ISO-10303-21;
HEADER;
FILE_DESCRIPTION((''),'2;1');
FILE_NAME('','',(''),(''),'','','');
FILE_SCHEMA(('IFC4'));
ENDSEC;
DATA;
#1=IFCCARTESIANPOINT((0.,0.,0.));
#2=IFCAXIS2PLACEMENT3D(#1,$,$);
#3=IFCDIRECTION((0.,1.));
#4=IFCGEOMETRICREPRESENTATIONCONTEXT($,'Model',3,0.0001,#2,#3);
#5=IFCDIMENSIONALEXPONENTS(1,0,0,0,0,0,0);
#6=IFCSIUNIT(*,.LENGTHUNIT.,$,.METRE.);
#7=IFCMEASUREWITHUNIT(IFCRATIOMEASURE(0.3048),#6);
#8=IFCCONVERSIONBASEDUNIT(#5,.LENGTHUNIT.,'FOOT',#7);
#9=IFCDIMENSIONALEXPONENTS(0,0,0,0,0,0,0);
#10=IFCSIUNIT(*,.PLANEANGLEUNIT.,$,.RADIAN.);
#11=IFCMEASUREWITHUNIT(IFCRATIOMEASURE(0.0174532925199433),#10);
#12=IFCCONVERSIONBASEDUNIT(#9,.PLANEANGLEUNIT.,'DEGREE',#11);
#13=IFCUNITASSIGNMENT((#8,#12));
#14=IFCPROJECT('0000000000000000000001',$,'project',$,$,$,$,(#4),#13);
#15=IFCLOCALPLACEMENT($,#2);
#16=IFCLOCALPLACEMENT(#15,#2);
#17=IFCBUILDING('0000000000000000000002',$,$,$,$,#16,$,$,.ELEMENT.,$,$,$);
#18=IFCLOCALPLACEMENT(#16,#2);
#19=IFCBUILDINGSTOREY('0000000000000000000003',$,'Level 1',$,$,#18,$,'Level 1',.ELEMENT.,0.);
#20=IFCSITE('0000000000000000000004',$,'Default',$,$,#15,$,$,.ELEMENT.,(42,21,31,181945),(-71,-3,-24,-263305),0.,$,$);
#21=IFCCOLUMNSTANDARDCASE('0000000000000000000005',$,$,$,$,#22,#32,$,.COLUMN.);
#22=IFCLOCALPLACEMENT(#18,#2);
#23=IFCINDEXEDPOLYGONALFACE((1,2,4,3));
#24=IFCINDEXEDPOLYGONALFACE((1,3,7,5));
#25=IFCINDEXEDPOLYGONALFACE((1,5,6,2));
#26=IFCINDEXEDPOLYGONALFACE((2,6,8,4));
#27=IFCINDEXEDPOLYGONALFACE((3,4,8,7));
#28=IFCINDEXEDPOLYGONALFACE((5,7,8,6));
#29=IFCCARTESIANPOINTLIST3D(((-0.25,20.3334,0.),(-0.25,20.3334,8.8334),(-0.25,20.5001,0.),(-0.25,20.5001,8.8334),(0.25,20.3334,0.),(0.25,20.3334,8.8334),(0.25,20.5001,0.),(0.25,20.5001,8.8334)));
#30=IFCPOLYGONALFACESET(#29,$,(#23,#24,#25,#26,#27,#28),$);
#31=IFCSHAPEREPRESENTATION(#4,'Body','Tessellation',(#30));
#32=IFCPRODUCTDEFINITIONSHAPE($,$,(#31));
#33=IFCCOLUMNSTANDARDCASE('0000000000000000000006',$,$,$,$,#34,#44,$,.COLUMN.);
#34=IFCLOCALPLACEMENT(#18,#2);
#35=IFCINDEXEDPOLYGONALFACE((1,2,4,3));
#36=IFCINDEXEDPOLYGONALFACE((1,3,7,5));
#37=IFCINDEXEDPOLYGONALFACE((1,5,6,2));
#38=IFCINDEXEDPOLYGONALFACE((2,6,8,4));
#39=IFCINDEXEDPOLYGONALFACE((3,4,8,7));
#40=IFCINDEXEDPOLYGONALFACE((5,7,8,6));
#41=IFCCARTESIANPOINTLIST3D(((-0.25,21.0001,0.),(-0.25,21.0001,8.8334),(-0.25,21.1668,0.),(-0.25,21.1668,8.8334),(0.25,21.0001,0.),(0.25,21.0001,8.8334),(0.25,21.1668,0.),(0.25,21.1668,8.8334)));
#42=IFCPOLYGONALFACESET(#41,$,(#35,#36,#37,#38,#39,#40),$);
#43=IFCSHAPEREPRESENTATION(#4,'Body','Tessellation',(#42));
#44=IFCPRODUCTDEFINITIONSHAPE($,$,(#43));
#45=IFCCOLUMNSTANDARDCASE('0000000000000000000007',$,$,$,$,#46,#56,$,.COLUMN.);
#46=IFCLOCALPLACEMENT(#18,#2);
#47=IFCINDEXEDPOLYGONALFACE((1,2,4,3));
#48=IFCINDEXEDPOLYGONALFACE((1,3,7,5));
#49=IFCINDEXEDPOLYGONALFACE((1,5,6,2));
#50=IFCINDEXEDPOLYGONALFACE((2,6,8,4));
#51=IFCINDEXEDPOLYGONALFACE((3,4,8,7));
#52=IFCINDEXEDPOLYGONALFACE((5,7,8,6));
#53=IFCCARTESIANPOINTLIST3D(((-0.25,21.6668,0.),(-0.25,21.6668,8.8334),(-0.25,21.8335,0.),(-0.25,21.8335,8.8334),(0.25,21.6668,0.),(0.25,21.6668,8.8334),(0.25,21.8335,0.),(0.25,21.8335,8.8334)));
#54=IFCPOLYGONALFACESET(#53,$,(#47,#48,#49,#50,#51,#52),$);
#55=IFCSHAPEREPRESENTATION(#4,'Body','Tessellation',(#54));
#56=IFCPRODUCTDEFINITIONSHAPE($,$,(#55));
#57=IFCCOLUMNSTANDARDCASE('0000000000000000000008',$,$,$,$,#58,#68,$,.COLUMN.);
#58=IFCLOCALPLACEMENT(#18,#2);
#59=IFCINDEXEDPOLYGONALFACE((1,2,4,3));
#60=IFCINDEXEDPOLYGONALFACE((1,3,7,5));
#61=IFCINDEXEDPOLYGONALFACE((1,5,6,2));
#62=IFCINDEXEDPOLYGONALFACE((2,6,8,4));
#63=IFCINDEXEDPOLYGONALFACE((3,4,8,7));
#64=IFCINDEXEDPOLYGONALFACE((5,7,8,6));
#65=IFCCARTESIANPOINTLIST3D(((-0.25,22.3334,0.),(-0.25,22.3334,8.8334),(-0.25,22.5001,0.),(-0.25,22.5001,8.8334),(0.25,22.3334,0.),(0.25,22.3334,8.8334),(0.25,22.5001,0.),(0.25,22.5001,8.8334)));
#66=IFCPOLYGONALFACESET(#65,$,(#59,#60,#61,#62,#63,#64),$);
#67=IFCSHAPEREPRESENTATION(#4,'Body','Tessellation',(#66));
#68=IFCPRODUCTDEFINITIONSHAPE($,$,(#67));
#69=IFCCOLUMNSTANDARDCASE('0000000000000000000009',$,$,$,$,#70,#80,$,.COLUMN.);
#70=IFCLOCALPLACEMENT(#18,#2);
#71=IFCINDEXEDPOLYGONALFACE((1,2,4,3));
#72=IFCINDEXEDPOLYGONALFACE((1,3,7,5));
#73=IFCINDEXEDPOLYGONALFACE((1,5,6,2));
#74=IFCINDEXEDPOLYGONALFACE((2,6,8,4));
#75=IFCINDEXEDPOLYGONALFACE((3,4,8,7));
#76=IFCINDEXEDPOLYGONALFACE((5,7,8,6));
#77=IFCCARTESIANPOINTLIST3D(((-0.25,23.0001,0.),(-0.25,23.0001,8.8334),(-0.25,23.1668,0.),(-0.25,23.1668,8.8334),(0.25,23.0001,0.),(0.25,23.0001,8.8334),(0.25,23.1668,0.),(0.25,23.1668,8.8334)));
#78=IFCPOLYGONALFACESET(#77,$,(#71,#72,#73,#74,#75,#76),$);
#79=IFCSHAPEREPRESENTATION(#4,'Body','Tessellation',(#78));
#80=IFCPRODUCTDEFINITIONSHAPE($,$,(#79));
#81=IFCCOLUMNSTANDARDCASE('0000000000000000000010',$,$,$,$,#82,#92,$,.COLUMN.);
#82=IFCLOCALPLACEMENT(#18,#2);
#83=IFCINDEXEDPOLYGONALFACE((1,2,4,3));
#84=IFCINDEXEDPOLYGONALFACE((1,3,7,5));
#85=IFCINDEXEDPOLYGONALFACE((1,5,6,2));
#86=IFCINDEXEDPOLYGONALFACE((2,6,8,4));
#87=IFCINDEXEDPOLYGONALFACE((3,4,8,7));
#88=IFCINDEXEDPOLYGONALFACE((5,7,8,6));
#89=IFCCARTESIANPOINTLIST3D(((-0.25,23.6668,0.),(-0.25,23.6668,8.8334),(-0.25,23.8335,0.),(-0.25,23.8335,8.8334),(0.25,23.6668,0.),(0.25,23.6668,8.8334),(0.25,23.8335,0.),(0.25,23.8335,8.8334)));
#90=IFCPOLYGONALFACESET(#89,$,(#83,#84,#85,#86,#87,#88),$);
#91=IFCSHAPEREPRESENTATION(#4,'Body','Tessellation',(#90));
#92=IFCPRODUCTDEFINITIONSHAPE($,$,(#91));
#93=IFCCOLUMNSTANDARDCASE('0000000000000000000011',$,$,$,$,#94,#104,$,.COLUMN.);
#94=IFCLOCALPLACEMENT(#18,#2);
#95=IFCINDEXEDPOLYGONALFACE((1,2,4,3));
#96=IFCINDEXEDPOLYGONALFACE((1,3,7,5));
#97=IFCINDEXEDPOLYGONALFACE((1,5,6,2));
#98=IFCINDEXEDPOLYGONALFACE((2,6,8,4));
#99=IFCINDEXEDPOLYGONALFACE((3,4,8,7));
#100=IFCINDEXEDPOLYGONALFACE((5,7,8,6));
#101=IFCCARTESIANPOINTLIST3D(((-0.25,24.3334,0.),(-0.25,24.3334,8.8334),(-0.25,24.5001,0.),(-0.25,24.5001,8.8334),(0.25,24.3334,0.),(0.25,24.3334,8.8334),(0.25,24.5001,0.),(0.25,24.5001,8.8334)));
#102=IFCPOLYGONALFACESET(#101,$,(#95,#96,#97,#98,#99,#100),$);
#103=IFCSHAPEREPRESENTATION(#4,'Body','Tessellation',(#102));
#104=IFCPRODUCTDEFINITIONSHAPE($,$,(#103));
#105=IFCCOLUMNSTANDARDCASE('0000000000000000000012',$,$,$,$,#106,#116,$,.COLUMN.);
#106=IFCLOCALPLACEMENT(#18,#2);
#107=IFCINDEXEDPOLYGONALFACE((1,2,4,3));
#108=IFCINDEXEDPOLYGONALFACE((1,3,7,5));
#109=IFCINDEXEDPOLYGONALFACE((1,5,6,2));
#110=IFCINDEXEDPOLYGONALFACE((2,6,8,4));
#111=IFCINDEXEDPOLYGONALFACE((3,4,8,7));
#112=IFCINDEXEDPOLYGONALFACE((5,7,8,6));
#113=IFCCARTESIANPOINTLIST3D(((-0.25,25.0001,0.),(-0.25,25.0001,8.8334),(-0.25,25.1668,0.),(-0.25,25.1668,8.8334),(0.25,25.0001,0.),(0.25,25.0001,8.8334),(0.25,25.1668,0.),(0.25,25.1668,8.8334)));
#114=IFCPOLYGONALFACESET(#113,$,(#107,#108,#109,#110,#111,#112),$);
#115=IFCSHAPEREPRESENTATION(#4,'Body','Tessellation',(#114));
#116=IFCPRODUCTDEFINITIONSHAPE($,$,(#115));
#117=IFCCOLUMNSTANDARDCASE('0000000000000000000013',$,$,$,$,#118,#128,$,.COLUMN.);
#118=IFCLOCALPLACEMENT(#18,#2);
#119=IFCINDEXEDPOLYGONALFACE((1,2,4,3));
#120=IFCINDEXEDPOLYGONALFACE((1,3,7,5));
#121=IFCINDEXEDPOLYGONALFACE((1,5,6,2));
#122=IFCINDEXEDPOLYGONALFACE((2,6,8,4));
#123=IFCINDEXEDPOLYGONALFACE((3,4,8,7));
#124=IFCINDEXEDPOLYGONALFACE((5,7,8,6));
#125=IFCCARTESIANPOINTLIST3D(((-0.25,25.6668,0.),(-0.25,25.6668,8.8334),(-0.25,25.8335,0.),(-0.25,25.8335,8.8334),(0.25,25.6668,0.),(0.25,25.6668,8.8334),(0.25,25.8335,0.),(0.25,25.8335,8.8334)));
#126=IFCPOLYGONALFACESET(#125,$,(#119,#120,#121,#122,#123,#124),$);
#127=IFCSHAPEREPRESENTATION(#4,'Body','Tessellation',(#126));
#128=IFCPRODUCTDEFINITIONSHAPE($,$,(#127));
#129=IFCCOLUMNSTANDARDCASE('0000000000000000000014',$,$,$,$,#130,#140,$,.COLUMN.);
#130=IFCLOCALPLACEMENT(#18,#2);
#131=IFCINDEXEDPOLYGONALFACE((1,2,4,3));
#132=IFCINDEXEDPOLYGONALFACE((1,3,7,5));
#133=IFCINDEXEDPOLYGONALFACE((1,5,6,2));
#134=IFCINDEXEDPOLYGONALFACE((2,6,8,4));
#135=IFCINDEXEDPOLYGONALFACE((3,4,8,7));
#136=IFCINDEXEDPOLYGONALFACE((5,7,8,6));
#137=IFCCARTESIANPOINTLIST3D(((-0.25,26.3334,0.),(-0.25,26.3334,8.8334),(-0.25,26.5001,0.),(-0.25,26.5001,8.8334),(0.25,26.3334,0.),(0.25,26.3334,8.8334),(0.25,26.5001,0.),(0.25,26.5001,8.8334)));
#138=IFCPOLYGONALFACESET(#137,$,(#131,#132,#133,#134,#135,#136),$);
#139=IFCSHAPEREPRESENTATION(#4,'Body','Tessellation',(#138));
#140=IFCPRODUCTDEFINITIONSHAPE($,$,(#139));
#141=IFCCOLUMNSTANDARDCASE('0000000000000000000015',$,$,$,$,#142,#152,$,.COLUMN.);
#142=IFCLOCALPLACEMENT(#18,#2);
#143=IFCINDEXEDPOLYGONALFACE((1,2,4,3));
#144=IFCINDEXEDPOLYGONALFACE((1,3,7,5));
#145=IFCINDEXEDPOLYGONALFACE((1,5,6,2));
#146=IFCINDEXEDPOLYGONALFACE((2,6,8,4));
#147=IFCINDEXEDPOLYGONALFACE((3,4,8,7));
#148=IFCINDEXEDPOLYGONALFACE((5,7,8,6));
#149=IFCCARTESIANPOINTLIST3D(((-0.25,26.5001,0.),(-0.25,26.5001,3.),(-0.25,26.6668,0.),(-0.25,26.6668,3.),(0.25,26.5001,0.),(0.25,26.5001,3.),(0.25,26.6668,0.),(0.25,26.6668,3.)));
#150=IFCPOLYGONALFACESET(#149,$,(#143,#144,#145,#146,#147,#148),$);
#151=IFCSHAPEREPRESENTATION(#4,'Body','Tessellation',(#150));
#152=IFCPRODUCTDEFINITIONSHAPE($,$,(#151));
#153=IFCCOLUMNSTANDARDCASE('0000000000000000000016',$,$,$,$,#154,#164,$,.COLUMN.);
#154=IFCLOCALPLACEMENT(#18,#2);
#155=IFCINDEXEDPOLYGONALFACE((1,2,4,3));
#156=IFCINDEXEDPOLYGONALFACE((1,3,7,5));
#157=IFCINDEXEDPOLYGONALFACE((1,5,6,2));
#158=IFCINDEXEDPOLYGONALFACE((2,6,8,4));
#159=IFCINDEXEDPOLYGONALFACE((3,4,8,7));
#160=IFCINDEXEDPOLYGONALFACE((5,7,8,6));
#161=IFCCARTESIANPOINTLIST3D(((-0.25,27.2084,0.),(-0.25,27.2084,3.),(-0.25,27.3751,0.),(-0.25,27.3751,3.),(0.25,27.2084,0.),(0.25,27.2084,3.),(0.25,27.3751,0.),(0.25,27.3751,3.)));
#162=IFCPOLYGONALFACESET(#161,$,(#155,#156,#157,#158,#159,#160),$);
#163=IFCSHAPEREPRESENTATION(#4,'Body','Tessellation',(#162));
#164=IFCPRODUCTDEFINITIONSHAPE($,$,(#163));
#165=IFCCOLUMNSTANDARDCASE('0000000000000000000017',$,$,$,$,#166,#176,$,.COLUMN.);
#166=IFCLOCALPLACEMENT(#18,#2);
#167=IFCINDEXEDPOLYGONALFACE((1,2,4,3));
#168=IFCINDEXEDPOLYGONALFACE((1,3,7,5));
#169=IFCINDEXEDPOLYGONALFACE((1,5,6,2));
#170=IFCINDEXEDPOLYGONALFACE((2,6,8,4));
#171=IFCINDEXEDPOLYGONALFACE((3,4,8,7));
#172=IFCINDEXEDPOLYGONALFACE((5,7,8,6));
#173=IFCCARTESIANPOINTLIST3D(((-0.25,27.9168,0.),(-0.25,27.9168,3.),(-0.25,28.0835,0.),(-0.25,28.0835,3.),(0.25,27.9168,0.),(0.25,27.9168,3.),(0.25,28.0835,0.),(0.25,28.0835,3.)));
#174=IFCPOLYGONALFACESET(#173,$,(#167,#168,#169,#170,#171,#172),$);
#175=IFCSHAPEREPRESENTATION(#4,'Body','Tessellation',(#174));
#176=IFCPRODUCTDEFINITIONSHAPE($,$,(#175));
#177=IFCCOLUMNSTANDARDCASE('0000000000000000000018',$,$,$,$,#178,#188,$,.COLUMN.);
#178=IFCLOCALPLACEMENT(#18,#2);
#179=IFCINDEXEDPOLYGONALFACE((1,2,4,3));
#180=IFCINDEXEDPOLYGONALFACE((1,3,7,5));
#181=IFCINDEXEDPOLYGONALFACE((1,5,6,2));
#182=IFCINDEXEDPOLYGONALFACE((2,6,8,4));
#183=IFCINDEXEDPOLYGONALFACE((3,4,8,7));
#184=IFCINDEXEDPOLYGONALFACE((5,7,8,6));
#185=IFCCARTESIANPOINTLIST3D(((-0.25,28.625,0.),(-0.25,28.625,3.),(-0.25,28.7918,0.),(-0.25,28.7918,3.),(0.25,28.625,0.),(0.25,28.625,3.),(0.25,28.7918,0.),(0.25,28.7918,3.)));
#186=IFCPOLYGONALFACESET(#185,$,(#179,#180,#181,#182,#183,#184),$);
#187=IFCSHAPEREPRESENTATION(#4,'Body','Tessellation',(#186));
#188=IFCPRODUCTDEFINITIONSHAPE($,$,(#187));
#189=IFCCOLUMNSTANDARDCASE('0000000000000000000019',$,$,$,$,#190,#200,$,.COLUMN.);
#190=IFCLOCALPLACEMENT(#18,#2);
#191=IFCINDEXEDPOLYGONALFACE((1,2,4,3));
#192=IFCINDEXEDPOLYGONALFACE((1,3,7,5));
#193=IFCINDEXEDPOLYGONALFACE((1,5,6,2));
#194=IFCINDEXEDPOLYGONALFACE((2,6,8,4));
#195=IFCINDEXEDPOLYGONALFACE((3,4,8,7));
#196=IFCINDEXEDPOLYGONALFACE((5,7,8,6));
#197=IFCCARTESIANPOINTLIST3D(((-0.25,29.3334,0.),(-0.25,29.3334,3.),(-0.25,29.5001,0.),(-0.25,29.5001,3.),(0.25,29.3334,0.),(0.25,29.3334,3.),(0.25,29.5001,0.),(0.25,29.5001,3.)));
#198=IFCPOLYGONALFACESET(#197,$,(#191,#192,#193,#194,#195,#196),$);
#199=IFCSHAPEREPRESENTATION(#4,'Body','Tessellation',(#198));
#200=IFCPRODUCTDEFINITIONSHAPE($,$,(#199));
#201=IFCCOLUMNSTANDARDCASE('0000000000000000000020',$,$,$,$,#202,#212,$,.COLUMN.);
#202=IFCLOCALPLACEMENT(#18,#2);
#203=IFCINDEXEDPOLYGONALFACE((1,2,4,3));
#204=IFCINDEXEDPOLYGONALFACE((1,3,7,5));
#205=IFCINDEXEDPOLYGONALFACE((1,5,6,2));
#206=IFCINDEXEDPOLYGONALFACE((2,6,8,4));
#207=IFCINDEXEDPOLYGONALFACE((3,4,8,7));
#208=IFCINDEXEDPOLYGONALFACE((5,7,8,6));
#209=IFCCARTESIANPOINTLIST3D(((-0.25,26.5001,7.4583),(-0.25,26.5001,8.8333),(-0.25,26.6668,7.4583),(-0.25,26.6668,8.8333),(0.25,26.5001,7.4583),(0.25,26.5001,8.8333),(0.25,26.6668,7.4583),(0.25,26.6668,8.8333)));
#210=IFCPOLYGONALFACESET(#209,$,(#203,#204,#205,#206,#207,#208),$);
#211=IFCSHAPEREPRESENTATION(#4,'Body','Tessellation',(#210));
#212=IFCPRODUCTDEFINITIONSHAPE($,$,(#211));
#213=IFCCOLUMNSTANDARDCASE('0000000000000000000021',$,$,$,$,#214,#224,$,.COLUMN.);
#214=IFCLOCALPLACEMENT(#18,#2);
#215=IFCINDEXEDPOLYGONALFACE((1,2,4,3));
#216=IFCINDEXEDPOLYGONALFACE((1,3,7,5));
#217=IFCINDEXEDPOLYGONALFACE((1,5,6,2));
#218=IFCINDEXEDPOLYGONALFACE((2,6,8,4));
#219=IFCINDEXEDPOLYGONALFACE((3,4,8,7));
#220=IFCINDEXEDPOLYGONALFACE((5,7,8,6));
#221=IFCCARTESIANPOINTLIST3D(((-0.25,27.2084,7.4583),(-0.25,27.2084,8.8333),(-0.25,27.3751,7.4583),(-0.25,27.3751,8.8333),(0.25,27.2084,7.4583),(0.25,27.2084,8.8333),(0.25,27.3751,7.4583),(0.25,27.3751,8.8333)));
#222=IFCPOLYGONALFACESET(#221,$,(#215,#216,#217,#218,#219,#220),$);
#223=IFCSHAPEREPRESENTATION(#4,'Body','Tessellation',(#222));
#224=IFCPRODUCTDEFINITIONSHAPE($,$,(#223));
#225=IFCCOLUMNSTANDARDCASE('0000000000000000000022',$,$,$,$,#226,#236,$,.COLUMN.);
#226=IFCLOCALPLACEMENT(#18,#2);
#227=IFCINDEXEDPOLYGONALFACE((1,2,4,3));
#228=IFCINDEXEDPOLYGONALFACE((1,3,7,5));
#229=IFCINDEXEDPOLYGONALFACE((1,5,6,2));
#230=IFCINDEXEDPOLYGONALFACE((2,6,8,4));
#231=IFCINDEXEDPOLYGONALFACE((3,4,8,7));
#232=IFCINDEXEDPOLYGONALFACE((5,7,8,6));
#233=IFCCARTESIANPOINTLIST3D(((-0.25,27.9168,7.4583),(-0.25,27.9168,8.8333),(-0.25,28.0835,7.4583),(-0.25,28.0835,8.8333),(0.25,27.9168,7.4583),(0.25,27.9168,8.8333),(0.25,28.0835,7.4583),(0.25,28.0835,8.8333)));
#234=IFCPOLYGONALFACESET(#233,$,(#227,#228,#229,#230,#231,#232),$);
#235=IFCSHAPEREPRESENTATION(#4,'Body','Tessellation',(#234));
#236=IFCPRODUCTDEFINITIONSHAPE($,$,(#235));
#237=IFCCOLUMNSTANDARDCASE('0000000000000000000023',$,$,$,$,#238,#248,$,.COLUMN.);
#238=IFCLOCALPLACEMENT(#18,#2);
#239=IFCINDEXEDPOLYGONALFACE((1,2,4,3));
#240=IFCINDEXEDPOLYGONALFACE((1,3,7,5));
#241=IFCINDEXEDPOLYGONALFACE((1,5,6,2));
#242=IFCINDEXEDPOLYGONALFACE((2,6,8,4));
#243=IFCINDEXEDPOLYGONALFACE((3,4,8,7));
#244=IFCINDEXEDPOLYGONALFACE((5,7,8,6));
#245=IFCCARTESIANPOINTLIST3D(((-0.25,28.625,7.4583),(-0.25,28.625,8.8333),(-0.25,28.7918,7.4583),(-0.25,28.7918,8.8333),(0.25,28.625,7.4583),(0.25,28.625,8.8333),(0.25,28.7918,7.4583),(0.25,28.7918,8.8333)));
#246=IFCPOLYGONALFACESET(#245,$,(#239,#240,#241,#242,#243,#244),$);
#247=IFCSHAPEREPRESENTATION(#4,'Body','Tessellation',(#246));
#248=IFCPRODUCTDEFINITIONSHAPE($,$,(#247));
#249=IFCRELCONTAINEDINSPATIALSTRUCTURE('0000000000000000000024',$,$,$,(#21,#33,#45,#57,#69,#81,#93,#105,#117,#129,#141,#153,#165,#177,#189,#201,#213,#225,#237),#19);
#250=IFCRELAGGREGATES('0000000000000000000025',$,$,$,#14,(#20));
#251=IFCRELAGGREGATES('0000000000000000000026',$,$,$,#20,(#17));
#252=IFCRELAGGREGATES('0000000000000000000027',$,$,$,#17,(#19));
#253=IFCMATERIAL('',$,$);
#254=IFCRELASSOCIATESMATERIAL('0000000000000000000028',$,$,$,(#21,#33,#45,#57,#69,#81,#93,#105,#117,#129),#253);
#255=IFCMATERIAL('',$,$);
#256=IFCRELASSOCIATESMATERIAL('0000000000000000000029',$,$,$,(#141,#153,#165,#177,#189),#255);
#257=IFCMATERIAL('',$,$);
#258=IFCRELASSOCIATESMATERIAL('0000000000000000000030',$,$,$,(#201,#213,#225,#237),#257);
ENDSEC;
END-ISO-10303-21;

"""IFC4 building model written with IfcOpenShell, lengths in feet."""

from ifc_helpers import new_model, entity, si_unit, converted_unit, direction, frame, origin, place, context, project, spatial, rectangle, extrude, material, element, save


model = new_model("IFC4")

# Units and contexts
model_context = context("Model", 3, precision=0.0001, world=origin(), true_north=direction((0.0, 1.0)))
ifc_project = project(units=[converted_unit("LENGTHUNIT", "FOOT", entity("IfcRatioMeasure", 0.3048), si_unit("LENGTHUNIT", "METRE"), dimensions=[1, 0, 0, 0, 0, 0, 0]), converted_unit("PLANEANGLEUNIT", "DEGREE", entity("IfcRatioMeasure", 0.0174532925199433), si_unit("PLANEANGLEUNIT", "RADIAN"), dimensions=[0, 0, 0, 0, 0, 0, 0])], contexts=[model_context])

# Site, building, storey
site_placement = place(None, origin())
site = spatial("IfcSite", under=ifc_project, at=site_placement, Name="Default", CompositionType="ELEMENT", RefLatitude=(42, 21, 31, 181945), RefLongitude=(-71, -3, -24, -263305), RefElevation=0.0)
building_placement = place(site_placement, origin())
building = spatial("IfcBuilding", under=site, at=building_placement, CompositionType="ELEMENT")
storey_placement = place(building_placement, origin())
storey = spatial("IfcBuildingStorey", under=building, at=storey_placement, Name="Level 1", LongName="Level 1", CompositionType="ELEMENT", Elevation=0.0)

# Columns
ifc_material_1 = material(Name="")
placement_1 = place(storey_placement, frame((0.0, -0.25, 0.0), z_axis=(0.0, 0.0, 1.0), x_axis=(0.0, 1.0, 0.0)))
for number, where, z_axis, x_axis in (
    (1, (20.6667, 0.0, 0.0), (0.0, 0.0, 1.0), (1.0, 0.0, 0.0)),
    (2, (21.3334, 0.0, 0.0), (0.0, 0.0, 1.0), (1.0, 0.0, 0.0)),
    (3, (22.0001, 0.0, 0.0), (0.0, 0.0, 1.0), (1.0, 0.0, 0.0)),
    (4, (22.6667, 0.0, 0.0), (0.0, 0.0, 1.0), (1.0, 0.0, 0.0)),
    (5, (23.3334, 0.0, 0.0), (0.0, 0.0, 1.0), (1.0, 0.0, 0.0)),
    (6, (24.0001, 0.0, 0.0), (0.0, 0.0, 1.0), (1.0, 0.0, 0.0)),
    (7, (24.6667, 0.0, 0.0), (0.0, 0.0, 1.0), (1.0, 0.0, 0.0)),
    (8, (25.3334, 0.0, 0.0), (0.0, 0.0, 1.0), (1.0, 0.0, 0.0)),
    (9, (26.0001, 0.0, 0.0), (0.0, 0.0, 1.0), (1.0, 0.0, 0.0)),
    (10, (26.6667, 0.0, 0.0), (0.0, 0.0, 1.0), (1.0, 0.0, 0.0)),
):
    element("IfcColumnStandardCase", number, at=place(placement_1, frame(where, z_axis=z_axis, x_axis=x_axis)), inside=storey, material=ifc_material_1, PredefinedType="COLUMN", context=model_context, shape_type="SweptSolid", body=[
        extrude(rectangle(XDim=0.1667, YDim=0.5), origin(), (0.0, 0.0, 1.0), 8.8334),
    ])
ifc_material_2 = material(Name="")
for number, where, z_axis, x_axis in (
    (11, (26.8334, 0.0, 0.0), (0.0, 0.0, 1.0), (1.0, 0.0, 0.0)),
    (12, (27.5417, 0.0, 0.0), (0.0, 0.0, 1.0), (1.0, 0.0, 0.0)),
    (13, (28.2501, 0.0, 0.0), (0.0, 0.0, 1.0), (1.0, 0.0, 0.0)),
    (14, (28.9584, 0.0, 0.0), (0.0, 0.0, 1.0), (1.0, 0.0, 0.0)),
    (15, (29.6667, 0.0, 0.0), (0.0, 0.0, 1.0), (1.0, 0.0, 0.0)),
):
    element("IfcColumnStandardCase", number, at=place(placement_1, frame(where, z_axis=z_axis, x_axis=x_axis)), inside=storey, material=ifc_material_2, PredefinedType="COLUMN", context=model_context, shape_type="SweptSolid", body=[
        extrude(rectangle(XDim=0.1667, YDim=0.5), origin(), (0.0, 0.0, 1.0), 3.0),
    ])
ifc_material_3 = material(Name="")
for number, where, z_axis, x_axis in (
    (16, (26.8334, 0.0, 7.4583), (0.0, 0.0, 1.0), (1.0, 0.0, 0.0)),
    (17, (27.5417, 0.0, 7.4583), (0.0, 0.0, 1.0), (1.0, 0.0, 0.0)),
    (18, (28.2501, 0.0, 7.4583), (0.0, 0.0, 1.0), (1.0, 0.0, 0.0)),
    (19, (28.9584, 0.0, 7.4583), (0.0, 0.0, 1.0), (1.0, 0.0, 0.0)),
):
    element("IfcColumnStandardCase", number, at=place(placement_1, frame(where, z_axis=z_axis, x_axis=x_axis)), inside=storey, material=ifc_material_3, PredefinedType="COLUMN", context=model_context, shape_type="SweptSolid", body=[
        extrude(rectangle(XDim=0.1667, YDim=0.5), origin(), (0.0, 0.0, 1.0), 1.375),
    ])

save(model, "model.ifc")
